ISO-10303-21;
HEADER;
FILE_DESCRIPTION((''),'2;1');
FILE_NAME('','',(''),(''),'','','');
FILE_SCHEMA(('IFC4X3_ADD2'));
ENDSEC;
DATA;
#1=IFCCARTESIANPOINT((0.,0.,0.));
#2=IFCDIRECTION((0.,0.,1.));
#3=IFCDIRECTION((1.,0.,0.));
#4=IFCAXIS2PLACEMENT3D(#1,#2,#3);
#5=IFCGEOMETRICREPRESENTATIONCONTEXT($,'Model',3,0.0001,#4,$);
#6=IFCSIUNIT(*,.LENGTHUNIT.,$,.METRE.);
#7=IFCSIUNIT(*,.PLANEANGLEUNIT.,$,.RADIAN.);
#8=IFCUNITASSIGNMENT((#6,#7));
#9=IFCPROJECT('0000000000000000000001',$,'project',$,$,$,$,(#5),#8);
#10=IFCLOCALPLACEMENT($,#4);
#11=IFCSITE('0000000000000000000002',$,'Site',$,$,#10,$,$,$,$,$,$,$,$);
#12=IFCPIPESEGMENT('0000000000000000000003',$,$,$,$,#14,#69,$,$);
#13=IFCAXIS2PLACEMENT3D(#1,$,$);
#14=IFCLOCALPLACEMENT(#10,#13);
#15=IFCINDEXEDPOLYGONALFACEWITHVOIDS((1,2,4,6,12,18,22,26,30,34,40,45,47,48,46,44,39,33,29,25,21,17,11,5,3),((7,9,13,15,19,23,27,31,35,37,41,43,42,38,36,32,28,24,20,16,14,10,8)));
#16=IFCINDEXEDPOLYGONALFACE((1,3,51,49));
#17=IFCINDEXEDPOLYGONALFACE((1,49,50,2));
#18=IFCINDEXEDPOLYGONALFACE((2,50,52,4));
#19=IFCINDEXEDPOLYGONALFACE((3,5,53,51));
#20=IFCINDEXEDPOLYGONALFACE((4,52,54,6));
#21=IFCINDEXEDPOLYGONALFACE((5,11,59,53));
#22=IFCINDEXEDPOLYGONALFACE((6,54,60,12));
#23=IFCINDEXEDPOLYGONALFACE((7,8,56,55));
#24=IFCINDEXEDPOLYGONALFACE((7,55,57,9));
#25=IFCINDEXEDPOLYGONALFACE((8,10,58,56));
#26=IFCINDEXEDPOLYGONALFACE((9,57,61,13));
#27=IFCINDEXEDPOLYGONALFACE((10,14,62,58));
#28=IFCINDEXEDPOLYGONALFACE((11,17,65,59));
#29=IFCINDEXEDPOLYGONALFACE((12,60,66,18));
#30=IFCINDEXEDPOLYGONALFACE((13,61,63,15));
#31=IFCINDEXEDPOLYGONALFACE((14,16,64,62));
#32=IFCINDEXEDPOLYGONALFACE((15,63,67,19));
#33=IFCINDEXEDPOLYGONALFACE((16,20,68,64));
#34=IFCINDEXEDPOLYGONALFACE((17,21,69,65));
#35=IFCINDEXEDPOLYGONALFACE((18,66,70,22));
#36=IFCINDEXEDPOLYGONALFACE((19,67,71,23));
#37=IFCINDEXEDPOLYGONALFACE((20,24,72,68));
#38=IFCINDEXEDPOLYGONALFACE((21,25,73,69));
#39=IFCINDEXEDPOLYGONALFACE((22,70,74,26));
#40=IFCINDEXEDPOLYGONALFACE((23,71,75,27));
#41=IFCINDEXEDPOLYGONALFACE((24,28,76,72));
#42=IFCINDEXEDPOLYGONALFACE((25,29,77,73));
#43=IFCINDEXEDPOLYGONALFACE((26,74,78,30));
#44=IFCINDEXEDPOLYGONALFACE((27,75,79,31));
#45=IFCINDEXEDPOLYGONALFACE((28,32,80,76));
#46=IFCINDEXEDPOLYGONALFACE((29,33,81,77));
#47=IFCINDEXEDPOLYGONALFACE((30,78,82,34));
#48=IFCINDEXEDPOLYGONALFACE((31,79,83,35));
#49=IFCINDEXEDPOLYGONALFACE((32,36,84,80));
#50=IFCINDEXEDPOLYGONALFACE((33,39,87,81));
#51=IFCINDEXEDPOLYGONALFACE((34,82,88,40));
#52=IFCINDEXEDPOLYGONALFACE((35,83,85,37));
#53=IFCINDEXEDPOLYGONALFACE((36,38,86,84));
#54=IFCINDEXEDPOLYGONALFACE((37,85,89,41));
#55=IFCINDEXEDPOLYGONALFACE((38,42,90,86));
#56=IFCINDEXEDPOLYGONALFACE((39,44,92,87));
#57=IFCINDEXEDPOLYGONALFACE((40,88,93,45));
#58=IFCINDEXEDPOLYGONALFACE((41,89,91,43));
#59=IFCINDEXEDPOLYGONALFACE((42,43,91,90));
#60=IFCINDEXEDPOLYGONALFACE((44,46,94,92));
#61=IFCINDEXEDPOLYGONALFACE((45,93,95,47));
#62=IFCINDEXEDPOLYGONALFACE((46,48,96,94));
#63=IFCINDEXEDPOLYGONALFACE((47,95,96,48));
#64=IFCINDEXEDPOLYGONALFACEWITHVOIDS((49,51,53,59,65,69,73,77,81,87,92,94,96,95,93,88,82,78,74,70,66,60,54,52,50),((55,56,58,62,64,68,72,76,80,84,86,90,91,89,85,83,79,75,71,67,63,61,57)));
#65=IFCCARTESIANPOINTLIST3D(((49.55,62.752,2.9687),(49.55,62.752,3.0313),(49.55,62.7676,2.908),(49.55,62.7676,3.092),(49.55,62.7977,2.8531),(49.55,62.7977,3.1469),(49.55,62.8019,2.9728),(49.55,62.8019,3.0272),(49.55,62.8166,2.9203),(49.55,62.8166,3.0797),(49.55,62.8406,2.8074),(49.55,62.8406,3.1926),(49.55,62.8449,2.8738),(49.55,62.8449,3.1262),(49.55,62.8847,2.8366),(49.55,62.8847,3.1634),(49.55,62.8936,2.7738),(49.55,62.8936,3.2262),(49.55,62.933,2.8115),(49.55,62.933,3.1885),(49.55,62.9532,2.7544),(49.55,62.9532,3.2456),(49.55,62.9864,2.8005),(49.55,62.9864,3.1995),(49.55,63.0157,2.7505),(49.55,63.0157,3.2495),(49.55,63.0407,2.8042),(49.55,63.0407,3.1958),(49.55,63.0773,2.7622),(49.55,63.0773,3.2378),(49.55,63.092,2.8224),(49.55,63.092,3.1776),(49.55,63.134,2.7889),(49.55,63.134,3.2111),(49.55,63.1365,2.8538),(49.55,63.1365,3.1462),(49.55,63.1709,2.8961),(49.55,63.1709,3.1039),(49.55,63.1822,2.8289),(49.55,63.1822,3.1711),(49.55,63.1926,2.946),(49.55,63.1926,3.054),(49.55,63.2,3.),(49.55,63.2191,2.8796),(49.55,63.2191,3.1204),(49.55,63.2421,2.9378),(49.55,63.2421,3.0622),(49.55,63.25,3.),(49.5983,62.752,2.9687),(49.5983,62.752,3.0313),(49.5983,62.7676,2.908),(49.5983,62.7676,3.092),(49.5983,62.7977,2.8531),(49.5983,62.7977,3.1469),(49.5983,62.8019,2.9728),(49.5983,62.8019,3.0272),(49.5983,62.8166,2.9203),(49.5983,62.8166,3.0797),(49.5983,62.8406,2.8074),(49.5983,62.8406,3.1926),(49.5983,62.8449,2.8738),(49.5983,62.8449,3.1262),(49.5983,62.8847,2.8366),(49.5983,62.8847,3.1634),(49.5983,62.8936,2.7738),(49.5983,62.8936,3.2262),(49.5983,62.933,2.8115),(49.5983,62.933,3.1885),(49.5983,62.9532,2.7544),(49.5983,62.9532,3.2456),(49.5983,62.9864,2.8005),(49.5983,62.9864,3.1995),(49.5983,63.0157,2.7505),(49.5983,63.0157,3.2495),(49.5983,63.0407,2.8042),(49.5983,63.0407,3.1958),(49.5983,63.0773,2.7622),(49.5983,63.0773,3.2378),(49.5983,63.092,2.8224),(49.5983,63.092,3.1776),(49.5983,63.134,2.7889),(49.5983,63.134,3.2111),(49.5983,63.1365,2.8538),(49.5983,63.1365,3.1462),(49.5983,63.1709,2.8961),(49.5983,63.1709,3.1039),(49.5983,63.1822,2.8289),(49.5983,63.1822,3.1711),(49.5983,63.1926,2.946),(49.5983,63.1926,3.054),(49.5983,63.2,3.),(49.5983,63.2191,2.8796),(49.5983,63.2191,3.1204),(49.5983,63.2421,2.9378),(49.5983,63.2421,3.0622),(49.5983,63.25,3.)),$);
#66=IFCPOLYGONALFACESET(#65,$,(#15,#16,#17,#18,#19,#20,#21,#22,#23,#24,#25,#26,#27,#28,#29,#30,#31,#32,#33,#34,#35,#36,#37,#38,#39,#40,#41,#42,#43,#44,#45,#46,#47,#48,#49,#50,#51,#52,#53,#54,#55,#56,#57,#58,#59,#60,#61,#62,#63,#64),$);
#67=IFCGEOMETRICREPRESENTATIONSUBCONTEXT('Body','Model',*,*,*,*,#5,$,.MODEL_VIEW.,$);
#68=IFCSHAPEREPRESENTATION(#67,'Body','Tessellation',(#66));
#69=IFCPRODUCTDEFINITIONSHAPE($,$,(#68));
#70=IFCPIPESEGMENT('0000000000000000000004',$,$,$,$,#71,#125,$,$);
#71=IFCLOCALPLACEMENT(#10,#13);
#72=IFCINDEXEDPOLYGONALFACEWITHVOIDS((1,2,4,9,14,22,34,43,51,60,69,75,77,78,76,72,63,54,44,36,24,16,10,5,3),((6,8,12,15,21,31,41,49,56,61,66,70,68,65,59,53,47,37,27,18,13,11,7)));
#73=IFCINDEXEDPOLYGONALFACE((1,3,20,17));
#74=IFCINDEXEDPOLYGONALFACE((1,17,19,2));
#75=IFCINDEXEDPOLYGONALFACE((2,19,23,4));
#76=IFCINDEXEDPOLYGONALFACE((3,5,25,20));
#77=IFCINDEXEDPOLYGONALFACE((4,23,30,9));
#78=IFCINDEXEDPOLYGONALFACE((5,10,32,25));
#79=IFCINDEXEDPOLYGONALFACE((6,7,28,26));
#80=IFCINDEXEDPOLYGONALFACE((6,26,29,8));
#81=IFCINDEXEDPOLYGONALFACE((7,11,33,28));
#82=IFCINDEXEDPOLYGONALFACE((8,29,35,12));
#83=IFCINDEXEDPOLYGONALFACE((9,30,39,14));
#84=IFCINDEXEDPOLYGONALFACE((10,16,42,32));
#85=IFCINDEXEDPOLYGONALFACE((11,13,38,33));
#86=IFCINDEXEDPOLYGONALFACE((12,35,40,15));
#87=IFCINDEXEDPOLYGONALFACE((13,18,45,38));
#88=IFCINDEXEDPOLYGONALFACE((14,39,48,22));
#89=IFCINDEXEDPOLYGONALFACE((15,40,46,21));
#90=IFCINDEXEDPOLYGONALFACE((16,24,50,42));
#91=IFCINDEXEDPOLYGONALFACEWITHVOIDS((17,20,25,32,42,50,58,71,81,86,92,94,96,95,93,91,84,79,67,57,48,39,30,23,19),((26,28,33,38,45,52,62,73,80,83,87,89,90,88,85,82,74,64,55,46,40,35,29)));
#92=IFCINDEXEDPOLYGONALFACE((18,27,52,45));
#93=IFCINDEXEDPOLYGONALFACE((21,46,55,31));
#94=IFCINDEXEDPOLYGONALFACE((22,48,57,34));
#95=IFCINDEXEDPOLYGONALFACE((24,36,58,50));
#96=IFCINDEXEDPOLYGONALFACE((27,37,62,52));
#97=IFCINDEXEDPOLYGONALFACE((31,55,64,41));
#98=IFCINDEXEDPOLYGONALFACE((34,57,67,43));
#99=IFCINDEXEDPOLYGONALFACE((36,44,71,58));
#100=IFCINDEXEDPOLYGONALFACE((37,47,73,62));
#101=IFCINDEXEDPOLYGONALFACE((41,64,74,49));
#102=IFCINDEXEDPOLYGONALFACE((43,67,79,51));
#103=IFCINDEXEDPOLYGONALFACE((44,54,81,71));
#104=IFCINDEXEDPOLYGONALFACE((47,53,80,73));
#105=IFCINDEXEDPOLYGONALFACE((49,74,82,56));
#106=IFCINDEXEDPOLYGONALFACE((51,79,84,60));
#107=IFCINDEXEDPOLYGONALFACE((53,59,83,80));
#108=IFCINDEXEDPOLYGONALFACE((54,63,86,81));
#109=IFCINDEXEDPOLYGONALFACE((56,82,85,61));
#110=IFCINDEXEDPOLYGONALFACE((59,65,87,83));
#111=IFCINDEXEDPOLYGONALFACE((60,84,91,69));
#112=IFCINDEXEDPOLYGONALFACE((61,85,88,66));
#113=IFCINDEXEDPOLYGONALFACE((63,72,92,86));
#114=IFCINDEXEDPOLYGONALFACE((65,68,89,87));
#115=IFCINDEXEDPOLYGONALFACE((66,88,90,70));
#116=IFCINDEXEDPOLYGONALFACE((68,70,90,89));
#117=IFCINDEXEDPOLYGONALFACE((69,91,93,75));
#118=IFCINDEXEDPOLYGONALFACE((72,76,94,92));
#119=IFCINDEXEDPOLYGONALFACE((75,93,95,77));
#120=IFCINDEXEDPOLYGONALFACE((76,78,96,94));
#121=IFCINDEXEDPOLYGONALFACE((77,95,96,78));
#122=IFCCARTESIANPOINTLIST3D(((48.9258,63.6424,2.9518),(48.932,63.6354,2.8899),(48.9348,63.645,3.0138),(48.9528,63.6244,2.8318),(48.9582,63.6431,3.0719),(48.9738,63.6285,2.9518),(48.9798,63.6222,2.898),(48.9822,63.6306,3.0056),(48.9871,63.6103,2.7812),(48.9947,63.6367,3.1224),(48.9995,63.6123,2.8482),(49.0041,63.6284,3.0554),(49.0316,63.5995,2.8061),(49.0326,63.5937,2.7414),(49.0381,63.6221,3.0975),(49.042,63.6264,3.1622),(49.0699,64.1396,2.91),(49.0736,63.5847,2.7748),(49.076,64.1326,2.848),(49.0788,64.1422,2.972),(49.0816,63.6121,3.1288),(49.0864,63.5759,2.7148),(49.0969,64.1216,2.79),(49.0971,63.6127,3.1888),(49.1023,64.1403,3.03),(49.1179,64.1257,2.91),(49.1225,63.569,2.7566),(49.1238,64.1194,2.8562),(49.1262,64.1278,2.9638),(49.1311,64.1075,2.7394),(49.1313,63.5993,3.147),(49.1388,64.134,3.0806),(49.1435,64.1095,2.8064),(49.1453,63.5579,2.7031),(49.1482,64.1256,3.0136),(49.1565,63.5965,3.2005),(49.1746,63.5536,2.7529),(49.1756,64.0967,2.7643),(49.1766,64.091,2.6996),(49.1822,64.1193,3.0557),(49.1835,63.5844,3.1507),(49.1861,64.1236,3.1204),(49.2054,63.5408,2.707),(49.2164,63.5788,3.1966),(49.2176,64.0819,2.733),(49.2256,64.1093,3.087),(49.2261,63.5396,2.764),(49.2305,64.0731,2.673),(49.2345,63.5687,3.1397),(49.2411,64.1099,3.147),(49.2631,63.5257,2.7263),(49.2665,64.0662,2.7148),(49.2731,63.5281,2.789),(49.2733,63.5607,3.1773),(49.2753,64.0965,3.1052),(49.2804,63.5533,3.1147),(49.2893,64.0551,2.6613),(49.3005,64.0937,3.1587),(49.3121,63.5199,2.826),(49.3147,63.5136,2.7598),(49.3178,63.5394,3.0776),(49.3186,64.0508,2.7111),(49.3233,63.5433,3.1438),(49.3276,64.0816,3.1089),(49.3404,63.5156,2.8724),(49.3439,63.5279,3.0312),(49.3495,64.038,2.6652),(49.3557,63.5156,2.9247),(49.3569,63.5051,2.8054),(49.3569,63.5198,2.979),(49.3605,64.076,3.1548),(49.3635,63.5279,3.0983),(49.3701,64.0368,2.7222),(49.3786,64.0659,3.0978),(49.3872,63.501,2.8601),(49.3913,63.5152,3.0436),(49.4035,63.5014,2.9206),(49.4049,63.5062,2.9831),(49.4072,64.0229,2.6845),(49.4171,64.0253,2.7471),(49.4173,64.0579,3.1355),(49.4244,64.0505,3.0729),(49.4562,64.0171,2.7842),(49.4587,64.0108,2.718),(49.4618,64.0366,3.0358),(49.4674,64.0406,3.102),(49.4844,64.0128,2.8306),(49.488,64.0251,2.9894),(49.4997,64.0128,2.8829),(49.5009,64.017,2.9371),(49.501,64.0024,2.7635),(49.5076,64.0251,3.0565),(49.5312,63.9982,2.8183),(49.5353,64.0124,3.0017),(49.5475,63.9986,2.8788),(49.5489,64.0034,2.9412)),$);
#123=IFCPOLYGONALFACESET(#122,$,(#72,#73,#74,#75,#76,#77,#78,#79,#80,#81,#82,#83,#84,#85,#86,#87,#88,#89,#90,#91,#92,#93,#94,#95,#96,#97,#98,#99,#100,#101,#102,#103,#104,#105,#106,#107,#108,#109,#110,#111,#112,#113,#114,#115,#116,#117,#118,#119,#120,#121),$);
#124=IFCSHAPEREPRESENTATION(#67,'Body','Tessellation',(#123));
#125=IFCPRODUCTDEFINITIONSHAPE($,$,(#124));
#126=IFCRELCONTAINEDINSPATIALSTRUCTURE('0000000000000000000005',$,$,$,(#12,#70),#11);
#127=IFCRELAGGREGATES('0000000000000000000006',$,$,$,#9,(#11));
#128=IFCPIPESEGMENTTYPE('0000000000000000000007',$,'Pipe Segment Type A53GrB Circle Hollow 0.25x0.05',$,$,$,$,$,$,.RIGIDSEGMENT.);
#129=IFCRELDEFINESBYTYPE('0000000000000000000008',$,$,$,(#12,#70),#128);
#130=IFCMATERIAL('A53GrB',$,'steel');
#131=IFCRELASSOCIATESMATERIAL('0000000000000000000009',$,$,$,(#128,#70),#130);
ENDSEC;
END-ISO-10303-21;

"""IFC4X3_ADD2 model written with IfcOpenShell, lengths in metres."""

from ifc_helpers import new_model, si_unit, frame, origin_with_axes, place, context, subcontext, project, spatial, hollow_circle, extrude, material, material_profile, profile_set, profile_usage, type_object, element, save


model = new_model("IFC4X3_ADD2")

# Units and contexts
model_context = context("Model", 3, precision=0.0001, world=origin_with_axes())
body_context = subcontext(model_context, "Body", "Model", "MODEL_VIEW")
ifc_project = project(units=[si_unit("LENGTHUNIT", "METRE"), si_unit("PLANEANGLEUNIT", "RADIAN")], contexts=[model_context])

# Site
site_placement = place(None, origin_with_axes())
site = spatial("IfcSite", under=ifc_project, at=site_placement, Name="Site")

# Pipe segments
ifc_material = material(Name="A53GrB", Category="steel")
ifc_material_profile = material_profile(ifc_material, hollow_circle(Radius=0.25, WallThickness=0.05))
ifc_profile_set = profile_set([ifc_material_profile], Name="A53GrB steel Circle Hollow 0.25x0.05")
pipe_segment_type = type_object("IfcPipeSegmentType", Name="Pipe Segment Type A53GrB Circle Hollow 0.25x0.05", PredefinedType="RIGIDSEGMENT", material=ifc_profile_set)
pipe_segment_1_placement = place(None, frame((49.55, 63.0, 3.0), z_axis=(1.0, 0.0, 0.0), x_axis=(0.0, 1.0, 0.0)))
element("IfcPipeSegment", 1, at=pipe_segment_1_placement, inside=site, type_object=pipe_segment_type, context=body_context, shape_type="SweptSolid", body=[
    extrude(hollow_circle(Radius=0.25, WallThickness=0.05), origin_with_axes(), (0.0, 0.0, 1.0), 0.0483),
])
ifc_profile_usage = profile_usage(ifc_profile_set, cardinal=5)
pipe_segment_2_placement = place(None, frame((49.1659, 63.5728, 2.9518), z_axis=(0.277372, 0.957382, -0.080527), x_axis=(-0.960501, 0.278276, 0.0)))
element("IfcPipeSegment", 2, at=pipe_segment_2_placement, inside=site, type_object=pipe_segment_type, material=ifc_profile_usage, context=body_context, shape_type="SweptSolid", body=[
    extrude(hollow_circle(Radius=0.25, WallThickness=0.05), origin_with_axes(), (0.0, 0.0, 1.0), 0.5193),
])

save(model, "model.ifc")
